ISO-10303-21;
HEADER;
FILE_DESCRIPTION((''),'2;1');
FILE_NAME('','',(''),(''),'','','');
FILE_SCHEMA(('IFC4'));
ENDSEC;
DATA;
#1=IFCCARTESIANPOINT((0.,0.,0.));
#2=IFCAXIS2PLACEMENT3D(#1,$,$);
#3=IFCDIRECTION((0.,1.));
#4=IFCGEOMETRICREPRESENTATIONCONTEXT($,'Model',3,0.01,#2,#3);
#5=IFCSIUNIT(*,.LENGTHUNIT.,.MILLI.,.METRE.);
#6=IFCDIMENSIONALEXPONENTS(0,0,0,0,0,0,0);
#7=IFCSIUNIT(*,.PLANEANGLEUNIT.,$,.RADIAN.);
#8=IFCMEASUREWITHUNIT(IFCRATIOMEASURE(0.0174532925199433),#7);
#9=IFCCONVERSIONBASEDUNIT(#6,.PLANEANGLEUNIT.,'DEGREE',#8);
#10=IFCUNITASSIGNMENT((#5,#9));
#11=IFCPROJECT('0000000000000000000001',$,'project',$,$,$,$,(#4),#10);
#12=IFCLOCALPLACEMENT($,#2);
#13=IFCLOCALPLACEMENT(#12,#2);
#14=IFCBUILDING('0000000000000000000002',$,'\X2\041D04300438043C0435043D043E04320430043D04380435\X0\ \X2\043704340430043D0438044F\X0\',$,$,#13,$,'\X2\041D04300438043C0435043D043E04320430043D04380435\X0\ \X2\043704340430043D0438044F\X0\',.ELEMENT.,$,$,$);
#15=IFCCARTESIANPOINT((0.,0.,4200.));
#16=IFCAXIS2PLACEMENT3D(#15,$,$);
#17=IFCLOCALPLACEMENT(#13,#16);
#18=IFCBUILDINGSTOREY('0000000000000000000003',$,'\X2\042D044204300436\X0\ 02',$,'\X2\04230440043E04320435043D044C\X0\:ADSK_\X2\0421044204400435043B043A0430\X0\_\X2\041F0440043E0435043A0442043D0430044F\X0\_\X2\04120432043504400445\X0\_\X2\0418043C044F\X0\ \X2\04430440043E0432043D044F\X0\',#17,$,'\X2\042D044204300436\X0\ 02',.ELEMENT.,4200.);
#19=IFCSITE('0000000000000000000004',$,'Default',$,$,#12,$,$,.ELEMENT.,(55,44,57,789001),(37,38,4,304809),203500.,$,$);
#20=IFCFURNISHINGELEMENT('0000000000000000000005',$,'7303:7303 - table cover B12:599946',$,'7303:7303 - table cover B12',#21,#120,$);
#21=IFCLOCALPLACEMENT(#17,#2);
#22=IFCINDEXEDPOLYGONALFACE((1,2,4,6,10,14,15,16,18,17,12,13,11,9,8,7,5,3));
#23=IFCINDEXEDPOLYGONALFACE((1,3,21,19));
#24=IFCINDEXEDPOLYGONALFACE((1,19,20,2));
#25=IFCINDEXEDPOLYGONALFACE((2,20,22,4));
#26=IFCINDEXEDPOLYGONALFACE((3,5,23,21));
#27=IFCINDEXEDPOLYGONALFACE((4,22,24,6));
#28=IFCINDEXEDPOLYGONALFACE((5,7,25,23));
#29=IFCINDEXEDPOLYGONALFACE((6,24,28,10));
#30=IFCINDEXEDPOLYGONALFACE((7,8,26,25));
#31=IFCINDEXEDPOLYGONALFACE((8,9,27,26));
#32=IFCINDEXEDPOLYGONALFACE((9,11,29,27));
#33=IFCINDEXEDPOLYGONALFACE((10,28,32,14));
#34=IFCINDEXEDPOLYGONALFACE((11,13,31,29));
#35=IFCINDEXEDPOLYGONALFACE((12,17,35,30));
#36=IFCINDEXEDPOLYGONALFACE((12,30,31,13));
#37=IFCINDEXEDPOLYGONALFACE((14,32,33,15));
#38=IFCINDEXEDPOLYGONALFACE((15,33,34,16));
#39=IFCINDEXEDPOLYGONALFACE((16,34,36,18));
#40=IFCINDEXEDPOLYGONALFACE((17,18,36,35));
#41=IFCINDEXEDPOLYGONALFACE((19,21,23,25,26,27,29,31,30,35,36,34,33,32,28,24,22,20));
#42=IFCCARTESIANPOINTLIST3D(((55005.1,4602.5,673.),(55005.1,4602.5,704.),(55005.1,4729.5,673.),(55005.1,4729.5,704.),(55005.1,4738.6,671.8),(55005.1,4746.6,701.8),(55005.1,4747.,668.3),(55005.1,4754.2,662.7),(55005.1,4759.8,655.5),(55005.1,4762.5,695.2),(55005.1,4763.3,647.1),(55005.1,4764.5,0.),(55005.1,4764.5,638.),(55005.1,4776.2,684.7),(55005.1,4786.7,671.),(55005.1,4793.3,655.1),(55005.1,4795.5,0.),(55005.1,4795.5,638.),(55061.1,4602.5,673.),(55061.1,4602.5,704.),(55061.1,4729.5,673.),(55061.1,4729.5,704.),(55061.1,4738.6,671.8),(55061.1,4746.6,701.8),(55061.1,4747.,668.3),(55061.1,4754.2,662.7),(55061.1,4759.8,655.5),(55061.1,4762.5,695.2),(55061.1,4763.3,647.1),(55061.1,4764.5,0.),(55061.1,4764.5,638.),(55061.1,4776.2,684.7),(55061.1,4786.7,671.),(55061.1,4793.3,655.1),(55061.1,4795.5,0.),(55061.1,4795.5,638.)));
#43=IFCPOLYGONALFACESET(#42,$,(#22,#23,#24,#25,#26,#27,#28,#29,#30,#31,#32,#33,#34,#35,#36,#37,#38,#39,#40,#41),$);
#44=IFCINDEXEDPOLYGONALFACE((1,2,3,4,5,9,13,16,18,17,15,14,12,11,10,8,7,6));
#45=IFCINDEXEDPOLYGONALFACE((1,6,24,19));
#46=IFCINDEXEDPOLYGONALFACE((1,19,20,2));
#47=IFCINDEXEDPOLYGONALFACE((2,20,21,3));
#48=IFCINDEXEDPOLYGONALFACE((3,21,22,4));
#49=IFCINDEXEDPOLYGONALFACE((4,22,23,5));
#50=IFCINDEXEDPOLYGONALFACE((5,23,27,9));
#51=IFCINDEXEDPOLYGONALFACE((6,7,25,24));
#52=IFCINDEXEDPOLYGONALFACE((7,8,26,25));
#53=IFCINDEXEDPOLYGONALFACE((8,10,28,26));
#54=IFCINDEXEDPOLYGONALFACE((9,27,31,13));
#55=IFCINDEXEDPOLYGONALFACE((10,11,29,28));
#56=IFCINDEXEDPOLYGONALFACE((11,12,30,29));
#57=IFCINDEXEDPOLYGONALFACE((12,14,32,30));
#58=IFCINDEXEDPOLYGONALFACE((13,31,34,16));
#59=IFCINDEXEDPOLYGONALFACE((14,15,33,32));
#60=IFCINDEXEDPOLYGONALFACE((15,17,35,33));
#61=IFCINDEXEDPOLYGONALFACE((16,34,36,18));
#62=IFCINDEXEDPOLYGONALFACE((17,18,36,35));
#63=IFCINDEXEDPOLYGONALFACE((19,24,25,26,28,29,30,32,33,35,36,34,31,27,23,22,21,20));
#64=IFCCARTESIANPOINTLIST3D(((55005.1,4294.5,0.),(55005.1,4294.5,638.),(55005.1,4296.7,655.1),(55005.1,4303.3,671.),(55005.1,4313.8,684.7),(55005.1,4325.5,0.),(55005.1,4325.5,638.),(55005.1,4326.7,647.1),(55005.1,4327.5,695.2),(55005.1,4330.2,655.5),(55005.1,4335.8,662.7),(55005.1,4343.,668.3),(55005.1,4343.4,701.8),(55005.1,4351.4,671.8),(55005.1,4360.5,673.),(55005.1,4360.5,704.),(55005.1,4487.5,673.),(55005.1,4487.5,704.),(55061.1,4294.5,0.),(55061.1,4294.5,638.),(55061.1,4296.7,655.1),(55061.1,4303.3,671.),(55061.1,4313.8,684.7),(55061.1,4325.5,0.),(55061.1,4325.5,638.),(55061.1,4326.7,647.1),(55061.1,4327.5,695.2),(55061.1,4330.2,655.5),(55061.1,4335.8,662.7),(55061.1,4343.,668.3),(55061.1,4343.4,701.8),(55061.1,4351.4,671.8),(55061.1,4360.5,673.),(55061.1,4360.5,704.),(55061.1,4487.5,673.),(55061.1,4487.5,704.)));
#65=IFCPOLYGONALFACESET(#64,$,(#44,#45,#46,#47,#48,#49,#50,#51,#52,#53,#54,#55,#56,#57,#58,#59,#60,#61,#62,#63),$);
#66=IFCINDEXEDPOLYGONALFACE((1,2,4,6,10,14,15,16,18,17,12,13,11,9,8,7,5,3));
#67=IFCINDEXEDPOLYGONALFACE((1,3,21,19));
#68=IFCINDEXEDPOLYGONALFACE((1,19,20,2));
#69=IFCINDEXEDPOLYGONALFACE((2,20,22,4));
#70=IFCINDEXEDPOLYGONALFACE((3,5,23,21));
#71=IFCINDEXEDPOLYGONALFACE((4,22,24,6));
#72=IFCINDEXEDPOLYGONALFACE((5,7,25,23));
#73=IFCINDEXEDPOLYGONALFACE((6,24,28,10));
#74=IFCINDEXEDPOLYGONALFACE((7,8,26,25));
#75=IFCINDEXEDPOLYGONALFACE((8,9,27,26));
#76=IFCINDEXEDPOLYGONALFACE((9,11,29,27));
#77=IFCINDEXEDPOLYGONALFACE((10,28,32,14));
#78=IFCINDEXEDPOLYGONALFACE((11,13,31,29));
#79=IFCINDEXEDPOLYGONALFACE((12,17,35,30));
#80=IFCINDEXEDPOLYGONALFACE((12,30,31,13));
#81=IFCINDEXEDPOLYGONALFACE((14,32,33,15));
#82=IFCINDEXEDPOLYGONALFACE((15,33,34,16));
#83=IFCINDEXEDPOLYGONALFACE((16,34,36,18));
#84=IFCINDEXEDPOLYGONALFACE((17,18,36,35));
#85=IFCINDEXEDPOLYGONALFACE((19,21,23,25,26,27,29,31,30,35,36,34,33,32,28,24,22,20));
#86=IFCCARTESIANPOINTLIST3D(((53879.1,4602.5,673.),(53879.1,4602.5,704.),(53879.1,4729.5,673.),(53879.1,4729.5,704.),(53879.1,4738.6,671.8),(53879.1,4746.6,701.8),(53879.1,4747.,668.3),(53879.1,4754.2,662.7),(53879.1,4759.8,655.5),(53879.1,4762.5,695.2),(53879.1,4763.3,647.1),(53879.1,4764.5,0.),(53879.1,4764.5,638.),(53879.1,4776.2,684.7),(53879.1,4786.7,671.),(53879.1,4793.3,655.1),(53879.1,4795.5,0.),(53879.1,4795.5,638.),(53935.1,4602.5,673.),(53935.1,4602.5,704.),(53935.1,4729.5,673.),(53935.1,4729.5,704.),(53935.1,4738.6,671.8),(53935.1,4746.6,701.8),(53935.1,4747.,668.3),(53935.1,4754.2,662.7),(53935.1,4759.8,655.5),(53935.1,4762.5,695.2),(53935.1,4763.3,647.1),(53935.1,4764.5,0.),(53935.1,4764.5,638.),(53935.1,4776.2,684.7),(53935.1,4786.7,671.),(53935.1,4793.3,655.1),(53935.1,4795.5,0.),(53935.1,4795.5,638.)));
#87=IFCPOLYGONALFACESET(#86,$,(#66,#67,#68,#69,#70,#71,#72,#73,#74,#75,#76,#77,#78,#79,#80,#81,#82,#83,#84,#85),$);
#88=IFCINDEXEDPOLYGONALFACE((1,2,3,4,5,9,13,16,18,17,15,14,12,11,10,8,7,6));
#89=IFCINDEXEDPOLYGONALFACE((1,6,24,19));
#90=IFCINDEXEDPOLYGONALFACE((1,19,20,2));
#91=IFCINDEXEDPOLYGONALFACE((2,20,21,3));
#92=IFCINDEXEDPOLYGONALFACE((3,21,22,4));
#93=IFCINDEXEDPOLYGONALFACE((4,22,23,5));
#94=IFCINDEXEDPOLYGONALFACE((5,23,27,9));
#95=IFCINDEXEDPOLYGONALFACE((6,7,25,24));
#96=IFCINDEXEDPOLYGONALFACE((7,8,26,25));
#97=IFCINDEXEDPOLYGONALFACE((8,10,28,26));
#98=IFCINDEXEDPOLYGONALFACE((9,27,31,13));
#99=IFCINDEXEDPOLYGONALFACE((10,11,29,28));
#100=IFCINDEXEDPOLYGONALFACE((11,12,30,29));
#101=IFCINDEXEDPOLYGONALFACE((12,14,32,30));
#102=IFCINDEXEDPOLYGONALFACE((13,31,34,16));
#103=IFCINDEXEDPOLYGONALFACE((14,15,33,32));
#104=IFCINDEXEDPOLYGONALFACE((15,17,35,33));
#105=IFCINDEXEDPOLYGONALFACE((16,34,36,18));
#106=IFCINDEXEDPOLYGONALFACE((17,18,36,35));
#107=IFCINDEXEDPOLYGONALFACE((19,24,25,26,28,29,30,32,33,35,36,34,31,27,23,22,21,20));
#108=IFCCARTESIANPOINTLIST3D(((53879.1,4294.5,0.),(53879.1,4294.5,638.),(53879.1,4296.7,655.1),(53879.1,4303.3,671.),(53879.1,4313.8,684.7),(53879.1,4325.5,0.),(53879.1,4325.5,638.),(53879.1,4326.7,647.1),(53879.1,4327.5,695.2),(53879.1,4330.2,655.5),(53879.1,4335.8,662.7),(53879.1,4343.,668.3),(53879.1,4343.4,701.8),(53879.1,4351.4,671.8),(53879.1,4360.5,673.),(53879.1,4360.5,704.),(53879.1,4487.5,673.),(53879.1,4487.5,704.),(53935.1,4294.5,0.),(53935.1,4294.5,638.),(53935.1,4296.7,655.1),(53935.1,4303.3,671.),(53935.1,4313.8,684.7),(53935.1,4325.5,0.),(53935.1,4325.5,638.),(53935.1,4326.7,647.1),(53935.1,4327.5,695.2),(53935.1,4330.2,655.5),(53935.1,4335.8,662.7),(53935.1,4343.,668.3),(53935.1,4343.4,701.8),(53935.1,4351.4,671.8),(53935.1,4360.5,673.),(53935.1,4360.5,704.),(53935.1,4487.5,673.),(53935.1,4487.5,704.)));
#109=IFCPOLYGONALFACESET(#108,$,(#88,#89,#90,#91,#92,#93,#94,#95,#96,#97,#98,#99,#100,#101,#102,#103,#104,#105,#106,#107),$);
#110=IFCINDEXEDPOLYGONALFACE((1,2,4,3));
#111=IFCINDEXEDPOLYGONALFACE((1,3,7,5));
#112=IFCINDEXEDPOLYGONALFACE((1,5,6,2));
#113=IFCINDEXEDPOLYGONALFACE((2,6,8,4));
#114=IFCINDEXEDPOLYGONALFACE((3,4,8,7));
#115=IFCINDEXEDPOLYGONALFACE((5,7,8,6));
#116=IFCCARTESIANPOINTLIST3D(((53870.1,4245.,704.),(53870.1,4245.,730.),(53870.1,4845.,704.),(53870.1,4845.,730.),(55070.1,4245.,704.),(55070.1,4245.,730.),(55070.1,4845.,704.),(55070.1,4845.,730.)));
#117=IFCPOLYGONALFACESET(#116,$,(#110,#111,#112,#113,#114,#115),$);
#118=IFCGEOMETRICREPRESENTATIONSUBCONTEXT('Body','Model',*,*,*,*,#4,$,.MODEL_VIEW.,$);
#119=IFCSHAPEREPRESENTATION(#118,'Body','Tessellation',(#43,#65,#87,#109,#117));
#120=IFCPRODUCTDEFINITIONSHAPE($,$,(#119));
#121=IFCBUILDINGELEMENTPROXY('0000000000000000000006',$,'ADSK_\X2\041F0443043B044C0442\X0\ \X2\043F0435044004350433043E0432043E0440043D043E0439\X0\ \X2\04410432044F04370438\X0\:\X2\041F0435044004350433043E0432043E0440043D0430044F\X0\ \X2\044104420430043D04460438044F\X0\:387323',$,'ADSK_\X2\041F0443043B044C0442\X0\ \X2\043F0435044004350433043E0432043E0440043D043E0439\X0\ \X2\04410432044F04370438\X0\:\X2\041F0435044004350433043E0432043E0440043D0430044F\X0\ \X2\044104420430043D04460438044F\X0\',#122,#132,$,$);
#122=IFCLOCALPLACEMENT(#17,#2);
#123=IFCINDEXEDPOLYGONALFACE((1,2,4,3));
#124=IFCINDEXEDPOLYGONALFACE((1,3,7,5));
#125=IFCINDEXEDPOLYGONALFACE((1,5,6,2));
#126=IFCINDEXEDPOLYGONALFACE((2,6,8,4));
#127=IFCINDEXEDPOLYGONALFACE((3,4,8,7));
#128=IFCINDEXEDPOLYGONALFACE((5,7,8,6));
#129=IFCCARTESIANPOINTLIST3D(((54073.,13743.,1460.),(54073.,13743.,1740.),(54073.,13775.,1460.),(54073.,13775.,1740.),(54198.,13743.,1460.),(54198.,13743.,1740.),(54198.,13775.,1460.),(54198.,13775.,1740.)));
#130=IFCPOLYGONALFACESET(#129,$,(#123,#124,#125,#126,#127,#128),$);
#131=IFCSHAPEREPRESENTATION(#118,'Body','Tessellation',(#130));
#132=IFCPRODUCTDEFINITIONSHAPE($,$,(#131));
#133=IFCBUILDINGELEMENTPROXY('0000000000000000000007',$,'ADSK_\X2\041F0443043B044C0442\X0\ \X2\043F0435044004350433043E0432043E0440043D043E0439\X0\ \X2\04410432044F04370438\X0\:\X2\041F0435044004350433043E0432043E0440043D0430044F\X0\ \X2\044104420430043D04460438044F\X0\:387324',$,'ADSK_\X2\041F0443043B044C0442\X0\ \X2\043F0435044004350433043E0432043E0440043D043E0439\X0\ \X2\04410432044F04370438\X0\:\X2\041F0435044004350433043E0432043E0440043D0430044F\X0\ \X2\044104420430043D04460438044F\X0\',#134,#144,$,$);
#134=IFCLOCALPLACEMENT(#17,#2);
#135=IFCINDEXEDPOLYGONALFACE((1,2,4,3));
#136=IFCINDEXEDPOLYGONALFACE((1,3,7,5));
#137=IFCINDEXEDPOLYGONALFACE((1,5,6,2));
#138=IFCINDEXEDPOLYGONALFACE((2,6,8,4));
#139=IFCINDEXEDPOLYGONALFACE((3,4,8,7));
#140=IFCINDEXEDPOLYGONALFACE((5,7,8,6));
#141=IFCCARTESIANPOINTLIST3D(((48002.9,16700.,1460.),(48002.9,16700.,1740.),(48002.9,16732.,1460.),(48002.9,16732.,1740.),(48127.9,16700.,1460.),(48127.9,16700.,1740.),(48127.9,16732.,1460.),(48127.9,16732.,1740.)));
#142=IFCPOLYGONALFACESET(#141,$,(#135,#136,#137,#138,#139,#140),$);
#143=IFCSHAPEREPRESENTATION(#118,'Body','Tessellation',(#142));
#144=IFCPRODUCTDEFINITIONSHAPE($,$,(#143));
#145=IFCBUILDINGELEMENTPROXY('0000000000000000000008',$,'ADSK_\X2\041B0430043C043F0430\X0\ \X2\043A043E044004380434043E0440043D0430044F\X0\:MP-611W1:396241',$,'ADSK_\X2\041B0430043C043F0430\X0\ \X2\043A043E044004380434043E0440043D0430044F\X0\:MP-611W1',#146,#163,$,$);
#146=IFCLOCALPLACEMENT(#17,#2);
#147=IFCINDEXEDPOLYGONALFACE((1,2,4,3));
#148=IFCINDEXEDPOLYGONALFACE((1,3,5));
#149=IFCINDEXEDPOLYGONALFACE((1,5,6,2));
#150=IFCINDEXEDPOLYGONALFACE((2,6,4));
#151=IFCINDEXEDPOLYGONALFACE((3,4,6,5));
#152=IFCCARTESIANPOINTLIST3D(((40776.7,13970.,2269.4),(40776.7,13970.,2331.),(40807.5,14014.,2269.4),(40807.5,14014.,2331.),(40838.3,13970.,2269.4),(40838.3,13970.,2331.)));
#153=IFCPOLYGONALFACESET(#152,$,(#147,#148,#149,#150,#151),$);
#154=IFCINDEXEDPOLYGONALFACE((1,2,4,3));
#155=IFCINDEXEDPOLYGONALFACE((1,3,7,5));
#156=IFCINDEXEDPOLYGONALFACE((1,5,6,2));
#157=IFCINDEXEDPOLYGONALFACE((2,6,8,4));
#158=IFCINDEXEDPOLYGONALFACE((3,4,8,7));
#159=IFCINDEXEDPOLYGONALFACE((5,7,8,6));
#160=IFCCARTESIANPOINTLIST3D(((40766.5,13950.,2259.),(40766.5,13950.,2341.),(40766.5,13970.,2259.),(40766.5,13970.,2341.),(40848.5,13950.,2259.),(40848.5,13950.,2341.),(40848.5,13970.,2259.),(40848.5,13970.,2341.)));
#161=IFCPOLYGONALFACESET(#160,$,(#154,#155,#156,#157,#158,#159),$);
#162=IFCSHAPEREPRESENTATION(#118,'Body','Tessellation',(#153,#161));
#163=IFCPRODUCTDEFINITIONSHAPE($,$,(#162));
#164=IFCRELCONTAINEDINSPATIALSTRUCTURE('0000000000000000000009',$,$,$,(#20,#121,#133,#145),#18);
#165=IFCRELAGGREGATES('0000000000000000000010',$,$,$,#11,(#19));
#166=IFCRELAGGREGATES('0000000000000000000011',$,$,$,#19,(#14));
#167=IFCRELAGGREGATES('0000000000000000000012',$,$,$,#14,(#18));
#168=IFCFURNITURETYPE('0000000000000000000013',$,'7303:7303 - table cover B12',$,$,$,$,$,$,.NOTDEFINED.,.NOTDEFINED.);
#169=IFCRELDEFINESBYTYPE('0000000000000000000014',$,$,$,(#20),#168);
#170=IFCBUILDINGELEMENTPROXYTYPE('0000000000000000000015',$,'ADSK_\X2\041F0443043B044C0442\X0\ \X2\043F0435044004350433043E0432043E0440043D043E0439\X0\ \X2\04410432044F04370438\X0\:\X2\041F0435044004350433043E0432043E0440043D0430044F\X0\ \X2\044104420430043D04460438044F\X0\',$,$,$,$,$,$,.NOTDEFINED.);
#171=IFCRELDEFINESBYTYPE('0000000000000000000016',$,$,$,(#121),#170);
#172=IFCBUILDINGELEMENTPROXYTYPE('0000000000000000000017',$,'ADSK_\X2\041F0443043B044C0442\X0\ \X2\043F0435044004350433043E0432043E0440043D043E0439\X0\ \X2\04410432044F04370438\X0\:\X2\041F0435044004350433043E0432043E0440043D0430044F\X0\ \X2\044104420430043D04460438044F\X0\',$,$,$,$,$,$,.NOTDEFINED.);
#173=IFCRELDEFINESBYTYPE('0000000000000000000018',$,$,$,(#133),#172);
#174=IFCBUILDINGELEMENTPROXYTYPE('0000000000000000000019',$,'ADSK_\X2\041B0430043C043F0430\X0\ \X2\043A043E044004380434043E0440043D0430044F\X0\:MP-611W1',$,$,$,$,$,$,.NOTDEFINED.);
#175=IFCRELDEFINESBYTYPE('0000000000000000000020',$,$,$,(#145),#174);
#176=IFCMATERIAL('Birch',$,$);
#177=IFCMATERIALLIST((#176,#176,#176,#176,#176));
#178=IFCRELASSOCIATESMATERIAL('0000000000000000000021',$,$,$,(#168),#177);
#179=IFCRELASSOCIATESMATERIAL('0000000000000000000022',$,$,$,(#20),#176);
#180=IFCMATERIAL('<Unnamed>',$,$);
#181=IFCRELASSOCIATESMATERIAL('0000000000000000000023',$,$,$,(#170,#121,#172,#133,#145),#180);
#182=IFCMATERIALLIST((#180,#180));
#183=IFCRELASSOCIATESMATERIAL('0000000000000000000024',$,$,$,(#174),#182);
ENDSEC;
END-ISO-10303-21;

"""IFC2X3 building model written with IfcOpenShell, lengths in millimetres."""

from ifc_helpers import new_model, entity, si_unit, converted_unit, direction, frame, frame_2d, origin, origin_2d_with_axis, place, context, subcontext, project, spatial, polyline, circle_curve, parameter, trimmed, segment, composite_curve, rectangle, outline, extrude, source, transform, mapped, material, material_list, type_object, type_shapes, element, save


model = new_model("IFC2X3")

# Units and contexts
model_context = context("Model", 3, precision=0.01, world=origin(), true_north=direction((0.0, 1.0)))
body_context = subcontext(model_context, "Body", "Model", "MODEL_VIEW")
ifc_project = project(units=[si_unit("LENGTHUNIT", "METRE", prefix="MILLI"), converted_unit("PLANEANGLEUNIT", "DEGREE", entity("IfcRatioMeasure", 0.0174532925199433), si_unit("PLANEANGLEUNIT", "RADIAN"), dimensions=[0, 0, 0, 0, 0, 0, 0])], contexts=[model_context])

# Site, building, storey
site_placement = place(None, origin())
site = spatial("IfcSite", under=ifc_project, at=site_placement, Name="Default", CompositionType="ELEMENT", RefLatitude=(55, 44, 57, 789001), RefLongitude=(37, 38, 4, 304809), RefElevation=203500.0)
building_placement = place(site_placement, origin())
building = spatial("IfcBuilding", under=site, at=building_placement, Name="Наименование здания", LongName="Наименование здания", CompositionType="ELEMENT")
storey_placement = place(building_placement, frame((0.0, 0.0, 4200.0)))
storey = spatial("IfcBuildingStorey", under=building, at=storey_placement, Name="Этаж 02", ObjectType="Уровень:ADSK_Стрелка_Проектная_Вверх_Имя уровня", LongName="Этаж 02", CompositionType="ELEMENT", Elevation=4200.0)

# Furnishing element
ifc_material_1 = material(Name="Birch")
ifc_material_list_1 = material_list([ifc_material_1, ifc_material_1, ifc_material_1, ifc_material_1, ifc_material_1])
furniture_type = type_object("IfcFurnitureType", Name="7303:7303 - table cover B12", material=ifc_material_list_1)
shared_shape_1 = source(origin(), body_context, "Body", "SweptSolid", [
    extrude(outline(composite_curve([segment(polyline([(-200.2, -120.5), (-169.2, -120.5)]), True, "CONTINUOUS"), segment(polyline([(-169.2, -120.5), (-169.2, 6.5)]), True, "CONTINUOUS"), segment(trimmed(circle_curve(frame_2d((-134.2, 6.5), x_axis=(0.0, -1.0)), 35.0), [parameter(180.0)], [parameter(270.0)], True, "PARAMETER"), False, "CONTINUOUS"), segment(polyline([(-134.2, 41.5), (503.8, 41.5)]), True, "CONTINUOUS"), segment(polyline([(503.8, 41.5), (503.8, 72.5)]), True, "CONTINUOUS"), segment(polyline([(503.8, 72.5), (-134.2, 72.5)]), True, "CONTINUOUS"), segment(trimmed(circle_curve(frame_2d((-134.2, 6.5), x_axis=(0.0, -1.0)), 66.0), [parameter(180.0)], [parameter(270.0)], True, "PARAMETER"), True, "CONTINUOUS"), segment(polyline([(-200.2, 6.5), (-200.2, -120.5)]), True, "CONTINUOUS")], self_intersect=False)), frame((535.0, 178.0, 503.8), z_axis=(1.0, 0.0, 0.0), x_axis=(0.0, 0.0, -1.0)), (0.0, 0.0, 1.0), 56.0),
    extrude(outline(composite_curve([segment(polyline([(-120.5, -200.2), (6.5, -200.2)]), True, "CONTINUOUS"), segment(trimmed(circle_curve(frame_2d((6.5, -134.2), x_axis=(-1.0, 0.0)), 66.0), [parameter(90.0)], [parameter(180.0)], True, "PARAMETER"), True, "CONTINUOUS"), segment(polyline([(72.5, -134.2), (72.5, 503.8)]), True, "CONTINUOUS"), segment(polyline([(72.5, 503.8), (41.5, 503.8)]), True, "CONTINUOUS"), segment(polyline([(41.5, 503.8), (41.5, -134.2)]), True, "CONTINUOUS"), segment(trimmed(circle_curve(frame_2d((6.5, -134.2), x_axis=(-1.0, 0.0)), 35.0), [parameter(90.0)], [parameter(180.0)], True, "PARAMETER"), False, "CONTINUOUS"), segment(polyline([(6.5, -169.2), (-120.5, -169.2)]), True, "CONTINUOUS"), segment(polyline([(-120.5, -169.2), (-120.5, -200.2)]), True, "CONTINUOUS")], self_intersect=False)), frame((535.0, -178.0, 503.8), z_axis=(1.0, 0.0, 0.0), x_axis=(0.0, -1.0, 0.0)), (0.0, 0.0, 1.0), 56.0),
    extrude(outline(composite_curve([segment(polyline([(-200.2, -120.5), (-169.2, -120.5)]), True, "CONTINUOUS"), segment(polyline([(-169.2, -120.5), (-169.2, 6.5)]), True, "CONTINUOUS"), segment(trimmed(circle_curve(frame_2d((-134.2, 6.5), x_axis=(0.0, -1.0)), 35.0), [parameter(180.0)], [parameter(270.0)], True, "PARAMETER"), False, "CONTINUOUS"), segment(polyline([(-134.2, 41.5), (503.8, 41.5)]), True, "CONTINUOUS"), segment(polyline([(503.8, 41.5), (503.8, 72.5)]), True, "CONTINUOUS"), segment(polyline([(503.8, 72.5), (-134.2, 72.5)]), True, "CONTINUOUS"), segment(trimmed(circle_curve(frame_2d((-134.2, 6.5), x_axis=(0.0, -1.0)), 66.0), [parameter(180.0)], [parameter(270.0)], True, "PARAMETER"), True, "CONTINUOUS"), segment(polyline([(-200.2, 6.5), (-200.2, -120.5)]), True, "CONTINUOUS")], self_intersect=False)), frame((-591.0, 178.0, 503.8), z_axis=(1.0, 0.0, 0.0), x_axis=(0.0, 0.0, -1.0)), (0.0, 0.0, 1.0), 56.0),
    extrude(outline(composite_curve([segment(polyline([(-120.5, -200.2), (6.5, -200.2)]), True, "CONTINUOUS"), segment(trimmed(circle_curve(frame_2d((6.5, -134.2), x_axis=(-1.0, 0.0)), 66.0), [parameter(90.0)], [parameter(180.0)], True, "PARAMETER"), True, "CONTINUOUS"), segment(polyline([(72.5, -134.2), (72.5, 503.8)]), True, "CONTINUOUS"), segment(polyline([(72.5, 503.8), (41.5, 503.8)]), True, "CONTINUOUS"), segment(polyline([(41.5, 503.8), (41.5, -134.2)]), True, "CONTINUOUS"), segment(trimmed(circle_curve(frame_2d((6.5, -134.2), x_axis=(-1.0, 0.0)), 35.0), [parameter(90.0)], [parameter(180.0)], True, "PARAMETER"), False, "CONTINUOUS"), segment(polyline([(6.5, -169.2), (-120.5, -169.2)]), True, "CONTINUOUS"), segment(polyline([(-120.5, -169.2), (-120.5, -200.2)]), True, "CONTINUOUS")], self_intersect=False)), frame((-591.0, -178.0, 503.8), z_axis=(1.0, 0.0, 0.0), x_axis=(0.0, -1.0, 0.0)), (0.0, 0.0, 1.0), 56.0),
    extrude(rectangle(XDim=1200.0, YDim=600.0, at=origin_2d_with_axis()), frame((0.0, 0.0, 704.0), z_axis=(0.0, 0.0, 1.0), x_axis=(-1.0, 0.0, 0.0)), (0.0, 0.0, 1.0), 26.0),
])
type_shapes(furniture_type, [shared_shape_1])
furnishing_1_placement = place(storey_placement, frame((54470.1, 4545.0, 0.0)))
element("IfcFurnishingElement", 1, at=furnishing_1_placement, inside=storey, type_object=furniture_type, material=ifc_material_1, Name="7303:7303 - table cover B12:599946", ObjectType="7303:7303 - table cover B12", context=body_context, shape_type="MappedRepresentation", body=[
    mapped(shared_shape_1, transform((0.0, 0.0, 0.0), scale=1.0)),
])

# Building element proxies
ifc_material_2 = material(Name="<Unnamed>")
building_element_proxy_type_1 = type_object("IfcBuildingElementProxyType", Name="ADSK_Пульт переговорной связи:Переговорная станция", PredefinedType="NOTDEFINED", material=ifc_material_2)
shared_shape_2 = source(origin(), body_context, "Body", "SweptSolid", [
    extrude(rectangle(XDim=125.0, YDim=32.0, at=origin_2d_with_axis()), frame((0.0, 16.0, -140.0), z_axis=(0.0, 0.0, 1.0), x_axis=(-1.0, 0.0, 0.0)), (0.0, 0.0, 1.0), 280.0),
])
type_shapes(building_element_proxy_type_1, [shared_shape_2])
proxy_1_placement = place(storey_placement, frame((54135.5, 13743.0, 1600.0)))
element("IfcBuildingElementProxy", 2, at=proxy_1_placement, inside=storey, type_object=building_element_proxy_type_1, material=ifc_material_2, Name="ADSK_Пульт переговорной связи:Переговорная станция:387323", ObjectType="ADSK_Пульт переговорной связи:Переговорная станция", context=body_context, shape_type="MappedRepresentation", body=[
    mapped(shared_shape_2, transform((0.0, 0.0, 0.0), scale=1.0)),
])
building_element_proxy_type_2 = type_object("IfcBuildingElementProxyType", Name="ADSK_Пульт переговорной связи:Переговорная станция", PredefinedType="NOTDEFINED", material=ifc_material_2)
type_shapes(building_element_proxy_type_2, [shared_shape_2])
proxy_2_placement = place(storey_placement, frame((48065.4, 16732.0, 1600.0), z_axis=(0.0, 0.0, 1.0), x_axis=(-1.0, 0.0, 0.0)))
element("IfcBuildingElementProxy", 3, at=proxy_2_placement, inside=storey, type_object=building_element_proxy_type_2, material=ifc_material_2, Name="ADSK_Пульт переговорной связи:Переговорная станция:387324", ObjectType="ADSK_Пульт переговорной связи:Переговорная станция", context=body_context, shape_type="MappedRepresentation", body=[
    mapped(shared_shape_2, transform((0.0, 0.0, 0.0), scale=1.0)),
])
ifc_material_list_2 = material_list([ifc_material_2, ifc_material_2])
building_element_proxy_type_3 = type_object("IfcBuildingElementProxyType", Name="ADSK_Лампа коридорная:MP-611W1", PredefinedType="NOTDEFINED", material=ifc_material_list_2)
shared_shape_3 = source(origin(), body_context, "Body", "SweptSolid", [
    extrude(outline(polyline([(-30.8, -14.7), (30.8, -14.7), (0.0, 29.3), (-30.8, -14.7)])), frame((0.0, -2.7, -30.6), z_axis=(0.0, 0.0, 1.0), x_axis=(-1.0, 0.0, 0.0)), (0.0, 0.0, 1.0), 61.6),
    extrude(rectangle(XDim=82.0, YDim=20.0, at=origin_2d_with_axis()), frame((0.0, 22.0, -41.0), z_axis=(0.0, 0.0, 1.0), x_axis=(-1.0, 0.0, 0.0)), (0.0, 0.0, 1.0), 82.0),
])
type_shapes(building_element_proxy_type_3, [shared_shape_3])
proxy_3_placement = place(storey_placement, frame((40807.5, 13982.0, 2300.0), z_axis=(0.0, 0.0, 1.0), x_axis=(-1.0, 0.0, 0.0)))
element("IfcBuildingElementProxy", 4, at=proxy_3_placement, inside=storey, type_object=building_element_proxy_type_3, material=ifc_material_2, Name="ADSK_Лампа коридорная:MP-611W1:396241", ObjectType="ADSK_Лампа коридорная:MP-611W1", context=body_context, shape_type="MappedRepresentation", body=[
    mapped(shared_shape_3, transform((0.0, 0.0, 0.0), scale=1.0)),
])

save(model, "model.ifc")
